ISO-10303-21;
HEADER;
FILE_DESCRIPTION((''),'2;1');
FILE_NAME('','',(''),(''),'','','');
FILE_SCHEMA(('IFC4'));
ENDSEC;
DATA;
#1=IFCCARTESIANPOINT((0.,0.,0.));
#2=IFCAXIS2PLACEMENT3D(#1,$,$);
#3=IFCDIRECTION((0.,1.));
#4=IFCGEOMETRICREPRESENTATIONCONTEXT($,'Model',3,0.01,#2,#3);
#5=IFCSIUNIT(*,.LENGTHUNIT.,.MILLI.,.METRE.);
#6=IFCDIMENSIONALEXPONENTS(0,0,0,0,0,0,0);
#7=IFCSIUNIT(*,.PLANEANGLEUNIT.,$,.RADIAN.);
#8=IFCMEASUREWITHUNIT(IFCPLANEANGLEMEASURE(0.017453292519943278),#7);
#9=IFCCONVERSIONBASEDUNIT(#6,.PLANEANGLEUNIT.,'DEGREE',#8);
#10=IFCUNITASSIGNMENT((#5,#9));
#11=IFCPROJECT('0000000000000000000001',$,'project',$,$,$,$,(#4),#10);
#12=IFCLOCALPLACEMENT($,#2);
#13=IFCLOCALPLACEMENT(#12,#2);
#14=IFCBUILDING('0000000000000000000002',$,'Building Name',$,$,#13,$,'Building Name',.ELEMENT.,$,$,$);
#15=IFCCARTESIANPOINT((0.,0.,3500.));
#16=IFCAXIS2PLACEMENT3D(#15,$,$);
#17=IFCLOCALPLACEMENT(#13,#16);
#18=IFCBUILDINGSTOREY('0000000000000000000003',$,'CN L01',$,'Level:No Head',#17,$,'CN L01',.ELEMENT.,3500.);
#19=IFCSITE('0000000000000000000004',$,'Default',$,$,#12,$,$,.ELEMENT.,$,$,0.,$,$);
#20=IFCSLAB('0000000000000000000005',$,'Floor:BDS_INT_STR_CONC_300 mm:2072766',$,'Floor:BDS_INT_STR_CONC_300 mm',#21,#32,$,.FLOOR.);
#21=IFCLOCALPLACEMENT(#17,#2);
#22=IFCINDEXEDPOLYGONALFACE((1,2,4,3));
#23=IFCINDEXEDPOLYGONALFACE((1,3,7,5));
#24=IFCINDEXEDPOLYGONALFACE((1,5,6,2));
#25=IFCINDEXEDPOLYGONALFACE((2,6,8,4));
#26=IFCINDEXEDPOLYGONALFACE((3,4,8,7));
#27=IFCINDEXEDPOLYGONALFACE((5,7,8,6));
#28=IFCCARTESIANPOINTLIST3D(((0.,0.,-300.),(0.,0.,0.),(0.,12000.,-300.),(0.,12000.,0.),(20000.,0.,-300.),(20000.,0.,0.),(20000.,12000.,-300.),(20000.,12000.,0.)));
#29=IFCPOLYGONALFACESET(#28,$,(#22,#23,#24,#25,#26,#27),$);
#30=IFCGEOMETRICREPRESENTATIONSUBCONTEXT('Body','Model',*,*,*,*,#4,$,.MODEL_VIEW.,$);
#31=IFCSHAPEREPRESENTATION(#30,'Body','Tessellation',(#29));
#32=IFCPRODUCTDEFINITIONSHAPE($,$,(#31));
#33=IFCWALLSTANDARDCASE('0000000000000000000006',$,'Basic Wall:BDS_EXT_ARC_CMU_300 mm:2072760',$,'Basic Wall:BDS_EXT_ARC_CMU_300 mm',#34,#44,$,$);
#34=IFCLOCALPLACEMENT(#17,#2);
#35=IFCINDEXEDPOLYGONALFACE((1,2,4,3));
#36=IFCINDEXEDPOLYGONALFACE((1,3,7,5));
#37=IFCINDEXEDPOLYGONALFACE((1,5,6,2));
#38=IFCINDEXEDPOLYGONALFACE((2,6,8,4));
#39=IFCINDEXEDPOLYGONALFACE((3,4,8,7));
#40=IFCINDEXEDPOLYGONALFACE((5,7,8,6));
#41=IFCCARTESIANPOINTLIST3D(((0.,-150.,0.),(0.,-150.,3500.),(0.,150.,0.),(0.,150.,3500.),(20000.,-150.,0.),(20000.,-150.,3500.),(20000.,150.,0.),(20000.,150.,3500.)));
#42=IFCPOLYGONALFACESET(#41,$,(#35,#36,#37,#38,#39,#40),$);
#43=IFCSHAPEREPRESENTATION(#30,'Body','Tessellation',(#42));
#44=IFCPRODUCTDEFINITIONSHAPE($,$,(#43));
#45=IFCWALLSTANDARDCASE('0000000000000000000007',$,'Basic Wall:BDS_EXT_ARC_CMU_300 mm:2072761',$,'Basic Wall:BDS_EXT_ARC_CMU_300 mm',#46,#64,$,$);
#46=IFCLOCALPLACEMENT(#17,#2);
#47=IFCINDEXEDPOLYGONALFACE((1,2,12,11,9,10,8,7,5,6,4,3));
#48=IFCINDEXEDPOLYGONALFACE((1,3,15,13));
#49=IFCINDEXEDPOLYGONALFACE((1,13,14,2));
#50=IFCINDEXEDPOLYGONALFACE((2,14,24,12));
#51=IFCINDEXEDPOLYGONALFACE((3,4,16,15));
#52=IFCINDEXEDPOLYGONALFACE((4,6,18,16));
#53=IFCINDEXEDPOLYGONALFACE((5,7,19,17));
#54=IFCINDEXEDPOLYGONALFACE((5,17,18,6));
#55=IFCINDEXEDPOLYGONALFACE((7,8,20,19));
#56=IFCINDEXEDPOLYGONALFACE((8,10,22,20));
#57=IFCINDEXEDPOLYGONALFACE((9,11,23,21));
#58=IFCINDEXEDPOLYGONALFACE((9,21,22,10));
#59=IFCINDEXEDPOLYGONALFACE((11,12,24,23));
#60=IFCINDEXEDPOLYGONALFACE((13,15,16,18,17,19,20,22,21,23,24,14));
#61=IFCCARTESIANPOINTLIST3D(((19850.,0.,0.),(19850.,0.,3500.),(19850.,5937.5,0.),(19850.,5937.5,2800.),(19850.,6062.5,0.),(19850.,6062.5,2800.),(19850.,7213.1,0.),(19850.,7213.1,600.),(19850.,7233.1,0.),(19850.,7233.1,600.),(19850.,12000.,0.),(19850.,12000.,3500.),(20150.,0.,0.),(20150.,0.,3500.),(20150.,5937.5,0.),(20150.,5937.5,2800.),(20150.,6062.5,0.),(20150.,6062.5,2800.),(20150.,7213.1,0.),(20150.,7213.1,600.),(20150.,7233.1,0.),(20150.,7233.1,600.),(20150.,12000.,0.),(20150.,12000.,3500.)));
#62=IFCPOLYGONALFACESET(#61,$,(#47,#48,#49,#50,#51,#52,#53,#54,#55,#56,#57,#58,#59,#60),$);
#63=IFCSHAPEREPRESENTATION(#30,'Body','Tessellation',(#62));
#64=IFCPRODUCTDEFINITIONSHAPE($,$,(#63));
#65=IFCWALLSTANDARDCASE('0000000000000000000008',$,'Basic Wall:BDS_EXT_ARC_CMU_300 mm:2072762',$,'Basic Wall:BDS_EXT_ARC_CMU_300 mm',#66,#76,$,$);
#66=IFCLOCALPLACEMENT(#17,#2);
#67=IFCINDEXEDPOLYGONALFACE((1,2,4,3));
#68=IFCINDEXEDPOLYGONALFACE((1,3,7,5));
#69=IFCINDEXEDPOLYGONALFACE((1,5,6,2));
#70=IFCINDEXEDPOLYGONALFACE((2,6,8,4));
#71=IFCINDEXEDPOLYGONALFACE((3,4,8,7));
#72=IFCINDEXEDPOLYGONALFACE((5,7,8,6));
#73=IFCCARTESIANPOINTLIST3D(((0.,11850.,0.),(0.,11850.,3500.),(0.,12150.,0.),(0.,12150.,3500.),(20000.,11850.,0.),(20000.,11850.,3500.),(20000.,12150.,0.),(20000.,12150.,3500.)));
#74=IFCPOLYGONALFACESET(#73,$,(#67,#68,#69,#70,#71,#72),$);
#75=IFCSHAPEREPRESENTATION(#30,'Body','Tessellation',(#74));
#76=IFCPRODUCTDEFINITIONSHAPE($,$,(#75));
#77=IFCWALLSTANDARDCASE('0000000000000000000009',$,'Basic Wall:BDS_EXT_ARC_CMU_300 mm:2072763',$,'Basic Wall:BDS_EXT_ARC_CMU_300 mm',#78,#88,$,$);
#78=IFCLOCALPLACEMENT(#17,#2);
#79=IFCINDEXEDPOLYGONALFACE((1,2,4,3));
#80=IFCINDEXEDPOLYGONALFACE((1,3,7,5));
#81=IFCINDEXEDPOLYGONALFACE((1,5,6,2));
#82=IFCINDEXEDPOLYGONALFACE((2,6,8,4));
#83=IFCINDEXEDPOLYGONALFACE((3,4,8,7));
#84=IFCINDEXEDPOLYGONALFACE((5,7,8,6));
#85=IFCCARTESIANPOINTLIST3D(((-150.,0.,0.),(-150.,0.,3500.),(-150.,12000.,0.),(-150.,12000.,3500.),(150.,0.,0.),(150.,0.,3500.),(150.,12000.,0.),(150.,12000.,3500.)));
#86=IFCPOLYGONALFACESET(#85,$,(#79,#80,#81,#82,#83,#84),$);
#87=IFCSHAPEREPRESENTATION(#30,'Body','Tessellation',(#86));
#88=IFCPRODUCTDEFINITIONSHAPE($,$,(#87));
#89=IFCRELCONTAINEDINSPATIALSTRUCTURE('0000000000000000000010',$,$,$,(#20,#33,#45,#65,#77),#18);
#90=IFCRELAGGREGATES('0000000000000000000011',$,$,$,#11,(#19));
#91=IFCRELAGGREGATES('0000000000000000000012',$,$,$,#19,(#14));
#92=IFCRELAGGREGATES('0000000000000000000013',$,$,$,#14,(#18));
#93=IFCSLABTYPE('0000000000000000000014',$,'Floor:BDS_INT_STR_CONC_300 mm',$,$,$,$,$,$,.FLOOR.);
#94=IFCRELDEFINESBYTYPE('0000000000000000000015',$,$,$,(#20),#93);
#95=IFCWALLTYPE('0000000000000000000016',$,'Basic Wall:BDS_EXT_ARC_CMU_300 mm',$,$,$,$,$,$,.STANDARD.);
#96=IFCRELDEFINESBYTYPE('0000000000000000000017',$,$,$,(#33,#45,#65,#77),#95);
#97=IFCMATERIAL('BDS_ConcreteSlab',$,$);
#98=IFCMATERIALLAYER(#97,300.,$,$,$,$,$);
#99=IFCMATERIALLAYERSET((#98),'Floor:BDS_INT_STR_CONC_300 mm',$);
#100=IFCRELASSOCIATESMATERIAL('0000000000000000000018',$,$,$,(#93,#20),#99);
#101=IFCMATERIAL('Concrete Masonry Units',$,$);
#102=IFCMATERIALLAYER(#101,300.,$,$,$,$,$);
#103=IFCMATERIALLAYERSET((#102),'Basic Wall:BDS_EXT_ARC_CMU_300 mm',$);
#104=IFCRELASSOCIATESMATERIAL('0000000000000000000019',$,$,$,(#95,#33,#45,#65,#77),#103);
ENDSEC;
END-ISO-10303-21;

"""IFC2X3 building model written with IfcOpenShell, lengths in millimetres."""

from ifc_helpers import new_model, entity, si_unit, converted_unit, direction, frame, frame_2d, origin, origin_2d_with_axis, place, context, subcontext, project, spatial, polyline, rectangle, extrude, clip, bounded_halfspace, material, layer, layer_set, layer_usage, type_object, element, save


model = new_model("IFC2X3")

# Units and contexts
model_context = context("Model", 3, precision=0.01, world=origin(), true_north=direction((0.0, 1.0)))
body_context = subcontext(model_context, "Body", "Model", "MODEL_VIEW")
ifc_project = project(units=[si_unit("LENGTHUNIT", "METRE", prefix="MILLI"), converted_unit("PLANEANGLEUNIT", "DEGREE", entity("IfcPlaneAngleMeasure", 0.017453292519943278), si_unit("PLANEANGLEUNIT", "RADIAN"), dimensions=[0, 0, 0, 0, 0, 0, 0])], contexts=[model_context])

# Site, building, storey
site_placement = place(None, origin())
site = spatial("IfcSite", under=ifc_project, at=site_placement, Name="Default", CompositionType="ELEMENT", RefElevation=0.0)
building_placement = place(site_placement, origin())
building = spatial("IfcBuilding", under=site, at=building_placement, Name="Building Name", LongName="Building Name", CompositionType="ELEMENT")
storey_placement = place(building_placement, frame((0.0, 0.0, 3500.0)))
storey = spatial("IfcBuildingStorey", under=building, at=storey_placement, Name="CN L01", ObjectType="Level:No Head", LongName="CN L01", CompositionType="ELEMENT", Elevation=3500.0)

# Slab
ifc_material_1 = material(Name="BDS_ConcreteSlab")
ifc_layer_1 = layer(ifc_material_1, 300.0)
ifc_layer_set_1 = layer_set([ifc_layer_1], Name="Floor:BDS_INT_STR_CONC_300 mm")
ifc_layer_usage_1 = layer_usage(ifc_layer_set_1, "AXIS3", "POSITIVE", 0.0)
slab_type = type_object("IfcSlabType", Name="Floor:BDS_INT_STR_CONC_300 mm", PredefinedType="FLOOR", material=ifc_layer_set_1)
slab_placement = place(storey_placement, origin())
element("IfcSlab", 1, at=slab_placement, inside=storey, type_object=slab_type, material=ifc_layer_usage_1, Name="Floor:BDS_INT_STR_CONC_300 mm:2072766", ObjectType="Floor:BDS_INT_STR_CONC_300 mm", PredefinedType="FLOOR", context=body_context, shape_type="SweptSolid", body=[
    extrude(rectangle(XDim=12000.0, YDim=20000.0, at=origin_2d_with_axis()), frame((10000.0, 6000.0, 0.0), z_axis=(0.0, 0.0, -1.0), x_axis=(0.0, 1.0, 0.0)), (0.0, 0.0, 1.0), 300.0),
])

# Walls
ifc_material_2 = material(Name="Concrete Masonry Units")
ifc_layer_2 = layer(ifc_material_2, 300.0)
ifc_layer_set_2 = layer_set([ifc_layer_2], Name="Basic Wall:BDS_EXT_ARC_CMU_300 mm")
ifc_layer_usage_2 = layer_usage(ifc_layer_set_2, "AXIS2", "NEGATIVE", 150.0)
wall_type = type_object("IfcWallType", Name="Basic Wall:BDS_EXT_ARC_CMU_300 mm", PredefinedType="STANDARD", material=ifc_layer_set_2)
wall_1_placement = place(storey_placement, origin())
element("IfcWallStandardCase", 2, at=wall_1_placement, inside=storey, type_object=wall_type, material=ifc_layer_usage_2, Name="Basic Wall:BDS_EXT_ARC_CMU_300 mm:2072760", ObjectType="Basic Wall:BDS_EXT_ARC_CMU_300 mm", context=body_context, shape_type="SweptSolid", body=[
    extrude(rectangle(XDim=20000.0, YDim=300.0, at=frame_2d((10000.0, 0.0), x_axis=(-1.0, 0.0))), origin(), (0.0, 0.0, 1.0), 3500.0),
])
ifc_layer_usage_3 = layer_usage(ifc_layer_set_2, "AXIS2", "NEGATIVE", 150.0)
wall_2_placement = place(storey_placement, frame((20000.0, 0.0, 0.0), z_axis=(0.0, 0.0, 1.0), x_axis=(0.0, 1.0, 0.0)))
element("IfcWallStandardCase", 3, at=wall_2_placement, inside=storey, type_object=wall_type, material=ifc_layer_usage_3, Name="Basic Wall:BDS_EXT_ARC_CMU_300 mm:2072761", ObjectType="Basic Wall:BDS_EXT_ARC_CMU_300 mm", context=body_context, shape_type="Clipping", body=[
    clip(clip(extrude(rectangle(XDim=12000.0, YDim=300.0, at=frame_2d((6000.0, 0.0), x_axis=(-1.0, 0.0))), origin(), (0.0, 0.0, 1.0), 3500.0), bounded_halfspace(frame((7213.1, -150.0, 600.0)), True, frame((7213.1, -150.0, 600.0)), polyline([(0.0, 0.0), (20.0, 0.0), (20.0, 300.0), (0.0, 300.0), (0.0, 0.0)]))), bounded_halfspace(frame((5937.5, -150.0, 2800.0)), True, frame((5937.5, -150.0, 2800.0)), polyline([(0.0, 0.0), (125.0, 0.0), (125.0, 300.0), (0.0, 300.0), (0.0, 0.0)]))),
])
ifc_layer_usage_4 = layer_usage(ifc_layer_set_2, "AXIS2", "NEGATIVE", 150.0)
wall_3_placement = place(storey_placement, frame((20000.0, 12000.0, 0.0), z_axis=(0.0, 0.0, 1.0), x_axis=(-1.0, 0.0, 0.0)))
element("IfcWallStandardCase", 4, at=wall_3_placement, inside=storey, type_object=wall_type, material=ifc_layer_usage_4, Name="Basic Wall:BDS_EXT_ARC_CMU_300 mm:2072762", ObjectType="Basic Wall:BDS_EXT_ARC_CMU_300 mm", context=body_context, shape_type="SweptSolid", body=[
    extrude(rectangle(XDim=20000.0, YDim=300.0, at=frame_2d((10000.0, 0.0), x_axis=(-1.0, 0.0))), origin(), (0.0, 0.0, 1.0), 3500.0),
])
ifc_layer_usage_5 = layer_usage(ifc_layer_set_2, "AXIS2", "NEGATIVE", 150.0)
wall_4_placement = place(storey_placement, frame((0.0, 12000.0, 0.0), z_axis=(0.0, 0.0, 1.0), x_axis=(0.0, -1.0, 0.0)))
element("IfcWallStandardCase", 5, at=wall_4_placement, inside=storey, type_object=wall_type, material=ifc_layer_usage_5, Name="Basic Wall:BDS_EXT_ARC_CMU_300 mm:2072763", ObjectType="Basic Wall:BDS_EXT_ARC_CMU_300 mm", context=body_context, shape_type="SweptSolid", body=[
    extrude(rectangle(XDim=12000.0, YDim=300.0, at=frame_2d((6000.0, 0.0), x_axis=(-1.0, 0.0))), origin(), (0.0, 0.0, 1.0), 3500.0),
])

save(model, "model.ifc")
